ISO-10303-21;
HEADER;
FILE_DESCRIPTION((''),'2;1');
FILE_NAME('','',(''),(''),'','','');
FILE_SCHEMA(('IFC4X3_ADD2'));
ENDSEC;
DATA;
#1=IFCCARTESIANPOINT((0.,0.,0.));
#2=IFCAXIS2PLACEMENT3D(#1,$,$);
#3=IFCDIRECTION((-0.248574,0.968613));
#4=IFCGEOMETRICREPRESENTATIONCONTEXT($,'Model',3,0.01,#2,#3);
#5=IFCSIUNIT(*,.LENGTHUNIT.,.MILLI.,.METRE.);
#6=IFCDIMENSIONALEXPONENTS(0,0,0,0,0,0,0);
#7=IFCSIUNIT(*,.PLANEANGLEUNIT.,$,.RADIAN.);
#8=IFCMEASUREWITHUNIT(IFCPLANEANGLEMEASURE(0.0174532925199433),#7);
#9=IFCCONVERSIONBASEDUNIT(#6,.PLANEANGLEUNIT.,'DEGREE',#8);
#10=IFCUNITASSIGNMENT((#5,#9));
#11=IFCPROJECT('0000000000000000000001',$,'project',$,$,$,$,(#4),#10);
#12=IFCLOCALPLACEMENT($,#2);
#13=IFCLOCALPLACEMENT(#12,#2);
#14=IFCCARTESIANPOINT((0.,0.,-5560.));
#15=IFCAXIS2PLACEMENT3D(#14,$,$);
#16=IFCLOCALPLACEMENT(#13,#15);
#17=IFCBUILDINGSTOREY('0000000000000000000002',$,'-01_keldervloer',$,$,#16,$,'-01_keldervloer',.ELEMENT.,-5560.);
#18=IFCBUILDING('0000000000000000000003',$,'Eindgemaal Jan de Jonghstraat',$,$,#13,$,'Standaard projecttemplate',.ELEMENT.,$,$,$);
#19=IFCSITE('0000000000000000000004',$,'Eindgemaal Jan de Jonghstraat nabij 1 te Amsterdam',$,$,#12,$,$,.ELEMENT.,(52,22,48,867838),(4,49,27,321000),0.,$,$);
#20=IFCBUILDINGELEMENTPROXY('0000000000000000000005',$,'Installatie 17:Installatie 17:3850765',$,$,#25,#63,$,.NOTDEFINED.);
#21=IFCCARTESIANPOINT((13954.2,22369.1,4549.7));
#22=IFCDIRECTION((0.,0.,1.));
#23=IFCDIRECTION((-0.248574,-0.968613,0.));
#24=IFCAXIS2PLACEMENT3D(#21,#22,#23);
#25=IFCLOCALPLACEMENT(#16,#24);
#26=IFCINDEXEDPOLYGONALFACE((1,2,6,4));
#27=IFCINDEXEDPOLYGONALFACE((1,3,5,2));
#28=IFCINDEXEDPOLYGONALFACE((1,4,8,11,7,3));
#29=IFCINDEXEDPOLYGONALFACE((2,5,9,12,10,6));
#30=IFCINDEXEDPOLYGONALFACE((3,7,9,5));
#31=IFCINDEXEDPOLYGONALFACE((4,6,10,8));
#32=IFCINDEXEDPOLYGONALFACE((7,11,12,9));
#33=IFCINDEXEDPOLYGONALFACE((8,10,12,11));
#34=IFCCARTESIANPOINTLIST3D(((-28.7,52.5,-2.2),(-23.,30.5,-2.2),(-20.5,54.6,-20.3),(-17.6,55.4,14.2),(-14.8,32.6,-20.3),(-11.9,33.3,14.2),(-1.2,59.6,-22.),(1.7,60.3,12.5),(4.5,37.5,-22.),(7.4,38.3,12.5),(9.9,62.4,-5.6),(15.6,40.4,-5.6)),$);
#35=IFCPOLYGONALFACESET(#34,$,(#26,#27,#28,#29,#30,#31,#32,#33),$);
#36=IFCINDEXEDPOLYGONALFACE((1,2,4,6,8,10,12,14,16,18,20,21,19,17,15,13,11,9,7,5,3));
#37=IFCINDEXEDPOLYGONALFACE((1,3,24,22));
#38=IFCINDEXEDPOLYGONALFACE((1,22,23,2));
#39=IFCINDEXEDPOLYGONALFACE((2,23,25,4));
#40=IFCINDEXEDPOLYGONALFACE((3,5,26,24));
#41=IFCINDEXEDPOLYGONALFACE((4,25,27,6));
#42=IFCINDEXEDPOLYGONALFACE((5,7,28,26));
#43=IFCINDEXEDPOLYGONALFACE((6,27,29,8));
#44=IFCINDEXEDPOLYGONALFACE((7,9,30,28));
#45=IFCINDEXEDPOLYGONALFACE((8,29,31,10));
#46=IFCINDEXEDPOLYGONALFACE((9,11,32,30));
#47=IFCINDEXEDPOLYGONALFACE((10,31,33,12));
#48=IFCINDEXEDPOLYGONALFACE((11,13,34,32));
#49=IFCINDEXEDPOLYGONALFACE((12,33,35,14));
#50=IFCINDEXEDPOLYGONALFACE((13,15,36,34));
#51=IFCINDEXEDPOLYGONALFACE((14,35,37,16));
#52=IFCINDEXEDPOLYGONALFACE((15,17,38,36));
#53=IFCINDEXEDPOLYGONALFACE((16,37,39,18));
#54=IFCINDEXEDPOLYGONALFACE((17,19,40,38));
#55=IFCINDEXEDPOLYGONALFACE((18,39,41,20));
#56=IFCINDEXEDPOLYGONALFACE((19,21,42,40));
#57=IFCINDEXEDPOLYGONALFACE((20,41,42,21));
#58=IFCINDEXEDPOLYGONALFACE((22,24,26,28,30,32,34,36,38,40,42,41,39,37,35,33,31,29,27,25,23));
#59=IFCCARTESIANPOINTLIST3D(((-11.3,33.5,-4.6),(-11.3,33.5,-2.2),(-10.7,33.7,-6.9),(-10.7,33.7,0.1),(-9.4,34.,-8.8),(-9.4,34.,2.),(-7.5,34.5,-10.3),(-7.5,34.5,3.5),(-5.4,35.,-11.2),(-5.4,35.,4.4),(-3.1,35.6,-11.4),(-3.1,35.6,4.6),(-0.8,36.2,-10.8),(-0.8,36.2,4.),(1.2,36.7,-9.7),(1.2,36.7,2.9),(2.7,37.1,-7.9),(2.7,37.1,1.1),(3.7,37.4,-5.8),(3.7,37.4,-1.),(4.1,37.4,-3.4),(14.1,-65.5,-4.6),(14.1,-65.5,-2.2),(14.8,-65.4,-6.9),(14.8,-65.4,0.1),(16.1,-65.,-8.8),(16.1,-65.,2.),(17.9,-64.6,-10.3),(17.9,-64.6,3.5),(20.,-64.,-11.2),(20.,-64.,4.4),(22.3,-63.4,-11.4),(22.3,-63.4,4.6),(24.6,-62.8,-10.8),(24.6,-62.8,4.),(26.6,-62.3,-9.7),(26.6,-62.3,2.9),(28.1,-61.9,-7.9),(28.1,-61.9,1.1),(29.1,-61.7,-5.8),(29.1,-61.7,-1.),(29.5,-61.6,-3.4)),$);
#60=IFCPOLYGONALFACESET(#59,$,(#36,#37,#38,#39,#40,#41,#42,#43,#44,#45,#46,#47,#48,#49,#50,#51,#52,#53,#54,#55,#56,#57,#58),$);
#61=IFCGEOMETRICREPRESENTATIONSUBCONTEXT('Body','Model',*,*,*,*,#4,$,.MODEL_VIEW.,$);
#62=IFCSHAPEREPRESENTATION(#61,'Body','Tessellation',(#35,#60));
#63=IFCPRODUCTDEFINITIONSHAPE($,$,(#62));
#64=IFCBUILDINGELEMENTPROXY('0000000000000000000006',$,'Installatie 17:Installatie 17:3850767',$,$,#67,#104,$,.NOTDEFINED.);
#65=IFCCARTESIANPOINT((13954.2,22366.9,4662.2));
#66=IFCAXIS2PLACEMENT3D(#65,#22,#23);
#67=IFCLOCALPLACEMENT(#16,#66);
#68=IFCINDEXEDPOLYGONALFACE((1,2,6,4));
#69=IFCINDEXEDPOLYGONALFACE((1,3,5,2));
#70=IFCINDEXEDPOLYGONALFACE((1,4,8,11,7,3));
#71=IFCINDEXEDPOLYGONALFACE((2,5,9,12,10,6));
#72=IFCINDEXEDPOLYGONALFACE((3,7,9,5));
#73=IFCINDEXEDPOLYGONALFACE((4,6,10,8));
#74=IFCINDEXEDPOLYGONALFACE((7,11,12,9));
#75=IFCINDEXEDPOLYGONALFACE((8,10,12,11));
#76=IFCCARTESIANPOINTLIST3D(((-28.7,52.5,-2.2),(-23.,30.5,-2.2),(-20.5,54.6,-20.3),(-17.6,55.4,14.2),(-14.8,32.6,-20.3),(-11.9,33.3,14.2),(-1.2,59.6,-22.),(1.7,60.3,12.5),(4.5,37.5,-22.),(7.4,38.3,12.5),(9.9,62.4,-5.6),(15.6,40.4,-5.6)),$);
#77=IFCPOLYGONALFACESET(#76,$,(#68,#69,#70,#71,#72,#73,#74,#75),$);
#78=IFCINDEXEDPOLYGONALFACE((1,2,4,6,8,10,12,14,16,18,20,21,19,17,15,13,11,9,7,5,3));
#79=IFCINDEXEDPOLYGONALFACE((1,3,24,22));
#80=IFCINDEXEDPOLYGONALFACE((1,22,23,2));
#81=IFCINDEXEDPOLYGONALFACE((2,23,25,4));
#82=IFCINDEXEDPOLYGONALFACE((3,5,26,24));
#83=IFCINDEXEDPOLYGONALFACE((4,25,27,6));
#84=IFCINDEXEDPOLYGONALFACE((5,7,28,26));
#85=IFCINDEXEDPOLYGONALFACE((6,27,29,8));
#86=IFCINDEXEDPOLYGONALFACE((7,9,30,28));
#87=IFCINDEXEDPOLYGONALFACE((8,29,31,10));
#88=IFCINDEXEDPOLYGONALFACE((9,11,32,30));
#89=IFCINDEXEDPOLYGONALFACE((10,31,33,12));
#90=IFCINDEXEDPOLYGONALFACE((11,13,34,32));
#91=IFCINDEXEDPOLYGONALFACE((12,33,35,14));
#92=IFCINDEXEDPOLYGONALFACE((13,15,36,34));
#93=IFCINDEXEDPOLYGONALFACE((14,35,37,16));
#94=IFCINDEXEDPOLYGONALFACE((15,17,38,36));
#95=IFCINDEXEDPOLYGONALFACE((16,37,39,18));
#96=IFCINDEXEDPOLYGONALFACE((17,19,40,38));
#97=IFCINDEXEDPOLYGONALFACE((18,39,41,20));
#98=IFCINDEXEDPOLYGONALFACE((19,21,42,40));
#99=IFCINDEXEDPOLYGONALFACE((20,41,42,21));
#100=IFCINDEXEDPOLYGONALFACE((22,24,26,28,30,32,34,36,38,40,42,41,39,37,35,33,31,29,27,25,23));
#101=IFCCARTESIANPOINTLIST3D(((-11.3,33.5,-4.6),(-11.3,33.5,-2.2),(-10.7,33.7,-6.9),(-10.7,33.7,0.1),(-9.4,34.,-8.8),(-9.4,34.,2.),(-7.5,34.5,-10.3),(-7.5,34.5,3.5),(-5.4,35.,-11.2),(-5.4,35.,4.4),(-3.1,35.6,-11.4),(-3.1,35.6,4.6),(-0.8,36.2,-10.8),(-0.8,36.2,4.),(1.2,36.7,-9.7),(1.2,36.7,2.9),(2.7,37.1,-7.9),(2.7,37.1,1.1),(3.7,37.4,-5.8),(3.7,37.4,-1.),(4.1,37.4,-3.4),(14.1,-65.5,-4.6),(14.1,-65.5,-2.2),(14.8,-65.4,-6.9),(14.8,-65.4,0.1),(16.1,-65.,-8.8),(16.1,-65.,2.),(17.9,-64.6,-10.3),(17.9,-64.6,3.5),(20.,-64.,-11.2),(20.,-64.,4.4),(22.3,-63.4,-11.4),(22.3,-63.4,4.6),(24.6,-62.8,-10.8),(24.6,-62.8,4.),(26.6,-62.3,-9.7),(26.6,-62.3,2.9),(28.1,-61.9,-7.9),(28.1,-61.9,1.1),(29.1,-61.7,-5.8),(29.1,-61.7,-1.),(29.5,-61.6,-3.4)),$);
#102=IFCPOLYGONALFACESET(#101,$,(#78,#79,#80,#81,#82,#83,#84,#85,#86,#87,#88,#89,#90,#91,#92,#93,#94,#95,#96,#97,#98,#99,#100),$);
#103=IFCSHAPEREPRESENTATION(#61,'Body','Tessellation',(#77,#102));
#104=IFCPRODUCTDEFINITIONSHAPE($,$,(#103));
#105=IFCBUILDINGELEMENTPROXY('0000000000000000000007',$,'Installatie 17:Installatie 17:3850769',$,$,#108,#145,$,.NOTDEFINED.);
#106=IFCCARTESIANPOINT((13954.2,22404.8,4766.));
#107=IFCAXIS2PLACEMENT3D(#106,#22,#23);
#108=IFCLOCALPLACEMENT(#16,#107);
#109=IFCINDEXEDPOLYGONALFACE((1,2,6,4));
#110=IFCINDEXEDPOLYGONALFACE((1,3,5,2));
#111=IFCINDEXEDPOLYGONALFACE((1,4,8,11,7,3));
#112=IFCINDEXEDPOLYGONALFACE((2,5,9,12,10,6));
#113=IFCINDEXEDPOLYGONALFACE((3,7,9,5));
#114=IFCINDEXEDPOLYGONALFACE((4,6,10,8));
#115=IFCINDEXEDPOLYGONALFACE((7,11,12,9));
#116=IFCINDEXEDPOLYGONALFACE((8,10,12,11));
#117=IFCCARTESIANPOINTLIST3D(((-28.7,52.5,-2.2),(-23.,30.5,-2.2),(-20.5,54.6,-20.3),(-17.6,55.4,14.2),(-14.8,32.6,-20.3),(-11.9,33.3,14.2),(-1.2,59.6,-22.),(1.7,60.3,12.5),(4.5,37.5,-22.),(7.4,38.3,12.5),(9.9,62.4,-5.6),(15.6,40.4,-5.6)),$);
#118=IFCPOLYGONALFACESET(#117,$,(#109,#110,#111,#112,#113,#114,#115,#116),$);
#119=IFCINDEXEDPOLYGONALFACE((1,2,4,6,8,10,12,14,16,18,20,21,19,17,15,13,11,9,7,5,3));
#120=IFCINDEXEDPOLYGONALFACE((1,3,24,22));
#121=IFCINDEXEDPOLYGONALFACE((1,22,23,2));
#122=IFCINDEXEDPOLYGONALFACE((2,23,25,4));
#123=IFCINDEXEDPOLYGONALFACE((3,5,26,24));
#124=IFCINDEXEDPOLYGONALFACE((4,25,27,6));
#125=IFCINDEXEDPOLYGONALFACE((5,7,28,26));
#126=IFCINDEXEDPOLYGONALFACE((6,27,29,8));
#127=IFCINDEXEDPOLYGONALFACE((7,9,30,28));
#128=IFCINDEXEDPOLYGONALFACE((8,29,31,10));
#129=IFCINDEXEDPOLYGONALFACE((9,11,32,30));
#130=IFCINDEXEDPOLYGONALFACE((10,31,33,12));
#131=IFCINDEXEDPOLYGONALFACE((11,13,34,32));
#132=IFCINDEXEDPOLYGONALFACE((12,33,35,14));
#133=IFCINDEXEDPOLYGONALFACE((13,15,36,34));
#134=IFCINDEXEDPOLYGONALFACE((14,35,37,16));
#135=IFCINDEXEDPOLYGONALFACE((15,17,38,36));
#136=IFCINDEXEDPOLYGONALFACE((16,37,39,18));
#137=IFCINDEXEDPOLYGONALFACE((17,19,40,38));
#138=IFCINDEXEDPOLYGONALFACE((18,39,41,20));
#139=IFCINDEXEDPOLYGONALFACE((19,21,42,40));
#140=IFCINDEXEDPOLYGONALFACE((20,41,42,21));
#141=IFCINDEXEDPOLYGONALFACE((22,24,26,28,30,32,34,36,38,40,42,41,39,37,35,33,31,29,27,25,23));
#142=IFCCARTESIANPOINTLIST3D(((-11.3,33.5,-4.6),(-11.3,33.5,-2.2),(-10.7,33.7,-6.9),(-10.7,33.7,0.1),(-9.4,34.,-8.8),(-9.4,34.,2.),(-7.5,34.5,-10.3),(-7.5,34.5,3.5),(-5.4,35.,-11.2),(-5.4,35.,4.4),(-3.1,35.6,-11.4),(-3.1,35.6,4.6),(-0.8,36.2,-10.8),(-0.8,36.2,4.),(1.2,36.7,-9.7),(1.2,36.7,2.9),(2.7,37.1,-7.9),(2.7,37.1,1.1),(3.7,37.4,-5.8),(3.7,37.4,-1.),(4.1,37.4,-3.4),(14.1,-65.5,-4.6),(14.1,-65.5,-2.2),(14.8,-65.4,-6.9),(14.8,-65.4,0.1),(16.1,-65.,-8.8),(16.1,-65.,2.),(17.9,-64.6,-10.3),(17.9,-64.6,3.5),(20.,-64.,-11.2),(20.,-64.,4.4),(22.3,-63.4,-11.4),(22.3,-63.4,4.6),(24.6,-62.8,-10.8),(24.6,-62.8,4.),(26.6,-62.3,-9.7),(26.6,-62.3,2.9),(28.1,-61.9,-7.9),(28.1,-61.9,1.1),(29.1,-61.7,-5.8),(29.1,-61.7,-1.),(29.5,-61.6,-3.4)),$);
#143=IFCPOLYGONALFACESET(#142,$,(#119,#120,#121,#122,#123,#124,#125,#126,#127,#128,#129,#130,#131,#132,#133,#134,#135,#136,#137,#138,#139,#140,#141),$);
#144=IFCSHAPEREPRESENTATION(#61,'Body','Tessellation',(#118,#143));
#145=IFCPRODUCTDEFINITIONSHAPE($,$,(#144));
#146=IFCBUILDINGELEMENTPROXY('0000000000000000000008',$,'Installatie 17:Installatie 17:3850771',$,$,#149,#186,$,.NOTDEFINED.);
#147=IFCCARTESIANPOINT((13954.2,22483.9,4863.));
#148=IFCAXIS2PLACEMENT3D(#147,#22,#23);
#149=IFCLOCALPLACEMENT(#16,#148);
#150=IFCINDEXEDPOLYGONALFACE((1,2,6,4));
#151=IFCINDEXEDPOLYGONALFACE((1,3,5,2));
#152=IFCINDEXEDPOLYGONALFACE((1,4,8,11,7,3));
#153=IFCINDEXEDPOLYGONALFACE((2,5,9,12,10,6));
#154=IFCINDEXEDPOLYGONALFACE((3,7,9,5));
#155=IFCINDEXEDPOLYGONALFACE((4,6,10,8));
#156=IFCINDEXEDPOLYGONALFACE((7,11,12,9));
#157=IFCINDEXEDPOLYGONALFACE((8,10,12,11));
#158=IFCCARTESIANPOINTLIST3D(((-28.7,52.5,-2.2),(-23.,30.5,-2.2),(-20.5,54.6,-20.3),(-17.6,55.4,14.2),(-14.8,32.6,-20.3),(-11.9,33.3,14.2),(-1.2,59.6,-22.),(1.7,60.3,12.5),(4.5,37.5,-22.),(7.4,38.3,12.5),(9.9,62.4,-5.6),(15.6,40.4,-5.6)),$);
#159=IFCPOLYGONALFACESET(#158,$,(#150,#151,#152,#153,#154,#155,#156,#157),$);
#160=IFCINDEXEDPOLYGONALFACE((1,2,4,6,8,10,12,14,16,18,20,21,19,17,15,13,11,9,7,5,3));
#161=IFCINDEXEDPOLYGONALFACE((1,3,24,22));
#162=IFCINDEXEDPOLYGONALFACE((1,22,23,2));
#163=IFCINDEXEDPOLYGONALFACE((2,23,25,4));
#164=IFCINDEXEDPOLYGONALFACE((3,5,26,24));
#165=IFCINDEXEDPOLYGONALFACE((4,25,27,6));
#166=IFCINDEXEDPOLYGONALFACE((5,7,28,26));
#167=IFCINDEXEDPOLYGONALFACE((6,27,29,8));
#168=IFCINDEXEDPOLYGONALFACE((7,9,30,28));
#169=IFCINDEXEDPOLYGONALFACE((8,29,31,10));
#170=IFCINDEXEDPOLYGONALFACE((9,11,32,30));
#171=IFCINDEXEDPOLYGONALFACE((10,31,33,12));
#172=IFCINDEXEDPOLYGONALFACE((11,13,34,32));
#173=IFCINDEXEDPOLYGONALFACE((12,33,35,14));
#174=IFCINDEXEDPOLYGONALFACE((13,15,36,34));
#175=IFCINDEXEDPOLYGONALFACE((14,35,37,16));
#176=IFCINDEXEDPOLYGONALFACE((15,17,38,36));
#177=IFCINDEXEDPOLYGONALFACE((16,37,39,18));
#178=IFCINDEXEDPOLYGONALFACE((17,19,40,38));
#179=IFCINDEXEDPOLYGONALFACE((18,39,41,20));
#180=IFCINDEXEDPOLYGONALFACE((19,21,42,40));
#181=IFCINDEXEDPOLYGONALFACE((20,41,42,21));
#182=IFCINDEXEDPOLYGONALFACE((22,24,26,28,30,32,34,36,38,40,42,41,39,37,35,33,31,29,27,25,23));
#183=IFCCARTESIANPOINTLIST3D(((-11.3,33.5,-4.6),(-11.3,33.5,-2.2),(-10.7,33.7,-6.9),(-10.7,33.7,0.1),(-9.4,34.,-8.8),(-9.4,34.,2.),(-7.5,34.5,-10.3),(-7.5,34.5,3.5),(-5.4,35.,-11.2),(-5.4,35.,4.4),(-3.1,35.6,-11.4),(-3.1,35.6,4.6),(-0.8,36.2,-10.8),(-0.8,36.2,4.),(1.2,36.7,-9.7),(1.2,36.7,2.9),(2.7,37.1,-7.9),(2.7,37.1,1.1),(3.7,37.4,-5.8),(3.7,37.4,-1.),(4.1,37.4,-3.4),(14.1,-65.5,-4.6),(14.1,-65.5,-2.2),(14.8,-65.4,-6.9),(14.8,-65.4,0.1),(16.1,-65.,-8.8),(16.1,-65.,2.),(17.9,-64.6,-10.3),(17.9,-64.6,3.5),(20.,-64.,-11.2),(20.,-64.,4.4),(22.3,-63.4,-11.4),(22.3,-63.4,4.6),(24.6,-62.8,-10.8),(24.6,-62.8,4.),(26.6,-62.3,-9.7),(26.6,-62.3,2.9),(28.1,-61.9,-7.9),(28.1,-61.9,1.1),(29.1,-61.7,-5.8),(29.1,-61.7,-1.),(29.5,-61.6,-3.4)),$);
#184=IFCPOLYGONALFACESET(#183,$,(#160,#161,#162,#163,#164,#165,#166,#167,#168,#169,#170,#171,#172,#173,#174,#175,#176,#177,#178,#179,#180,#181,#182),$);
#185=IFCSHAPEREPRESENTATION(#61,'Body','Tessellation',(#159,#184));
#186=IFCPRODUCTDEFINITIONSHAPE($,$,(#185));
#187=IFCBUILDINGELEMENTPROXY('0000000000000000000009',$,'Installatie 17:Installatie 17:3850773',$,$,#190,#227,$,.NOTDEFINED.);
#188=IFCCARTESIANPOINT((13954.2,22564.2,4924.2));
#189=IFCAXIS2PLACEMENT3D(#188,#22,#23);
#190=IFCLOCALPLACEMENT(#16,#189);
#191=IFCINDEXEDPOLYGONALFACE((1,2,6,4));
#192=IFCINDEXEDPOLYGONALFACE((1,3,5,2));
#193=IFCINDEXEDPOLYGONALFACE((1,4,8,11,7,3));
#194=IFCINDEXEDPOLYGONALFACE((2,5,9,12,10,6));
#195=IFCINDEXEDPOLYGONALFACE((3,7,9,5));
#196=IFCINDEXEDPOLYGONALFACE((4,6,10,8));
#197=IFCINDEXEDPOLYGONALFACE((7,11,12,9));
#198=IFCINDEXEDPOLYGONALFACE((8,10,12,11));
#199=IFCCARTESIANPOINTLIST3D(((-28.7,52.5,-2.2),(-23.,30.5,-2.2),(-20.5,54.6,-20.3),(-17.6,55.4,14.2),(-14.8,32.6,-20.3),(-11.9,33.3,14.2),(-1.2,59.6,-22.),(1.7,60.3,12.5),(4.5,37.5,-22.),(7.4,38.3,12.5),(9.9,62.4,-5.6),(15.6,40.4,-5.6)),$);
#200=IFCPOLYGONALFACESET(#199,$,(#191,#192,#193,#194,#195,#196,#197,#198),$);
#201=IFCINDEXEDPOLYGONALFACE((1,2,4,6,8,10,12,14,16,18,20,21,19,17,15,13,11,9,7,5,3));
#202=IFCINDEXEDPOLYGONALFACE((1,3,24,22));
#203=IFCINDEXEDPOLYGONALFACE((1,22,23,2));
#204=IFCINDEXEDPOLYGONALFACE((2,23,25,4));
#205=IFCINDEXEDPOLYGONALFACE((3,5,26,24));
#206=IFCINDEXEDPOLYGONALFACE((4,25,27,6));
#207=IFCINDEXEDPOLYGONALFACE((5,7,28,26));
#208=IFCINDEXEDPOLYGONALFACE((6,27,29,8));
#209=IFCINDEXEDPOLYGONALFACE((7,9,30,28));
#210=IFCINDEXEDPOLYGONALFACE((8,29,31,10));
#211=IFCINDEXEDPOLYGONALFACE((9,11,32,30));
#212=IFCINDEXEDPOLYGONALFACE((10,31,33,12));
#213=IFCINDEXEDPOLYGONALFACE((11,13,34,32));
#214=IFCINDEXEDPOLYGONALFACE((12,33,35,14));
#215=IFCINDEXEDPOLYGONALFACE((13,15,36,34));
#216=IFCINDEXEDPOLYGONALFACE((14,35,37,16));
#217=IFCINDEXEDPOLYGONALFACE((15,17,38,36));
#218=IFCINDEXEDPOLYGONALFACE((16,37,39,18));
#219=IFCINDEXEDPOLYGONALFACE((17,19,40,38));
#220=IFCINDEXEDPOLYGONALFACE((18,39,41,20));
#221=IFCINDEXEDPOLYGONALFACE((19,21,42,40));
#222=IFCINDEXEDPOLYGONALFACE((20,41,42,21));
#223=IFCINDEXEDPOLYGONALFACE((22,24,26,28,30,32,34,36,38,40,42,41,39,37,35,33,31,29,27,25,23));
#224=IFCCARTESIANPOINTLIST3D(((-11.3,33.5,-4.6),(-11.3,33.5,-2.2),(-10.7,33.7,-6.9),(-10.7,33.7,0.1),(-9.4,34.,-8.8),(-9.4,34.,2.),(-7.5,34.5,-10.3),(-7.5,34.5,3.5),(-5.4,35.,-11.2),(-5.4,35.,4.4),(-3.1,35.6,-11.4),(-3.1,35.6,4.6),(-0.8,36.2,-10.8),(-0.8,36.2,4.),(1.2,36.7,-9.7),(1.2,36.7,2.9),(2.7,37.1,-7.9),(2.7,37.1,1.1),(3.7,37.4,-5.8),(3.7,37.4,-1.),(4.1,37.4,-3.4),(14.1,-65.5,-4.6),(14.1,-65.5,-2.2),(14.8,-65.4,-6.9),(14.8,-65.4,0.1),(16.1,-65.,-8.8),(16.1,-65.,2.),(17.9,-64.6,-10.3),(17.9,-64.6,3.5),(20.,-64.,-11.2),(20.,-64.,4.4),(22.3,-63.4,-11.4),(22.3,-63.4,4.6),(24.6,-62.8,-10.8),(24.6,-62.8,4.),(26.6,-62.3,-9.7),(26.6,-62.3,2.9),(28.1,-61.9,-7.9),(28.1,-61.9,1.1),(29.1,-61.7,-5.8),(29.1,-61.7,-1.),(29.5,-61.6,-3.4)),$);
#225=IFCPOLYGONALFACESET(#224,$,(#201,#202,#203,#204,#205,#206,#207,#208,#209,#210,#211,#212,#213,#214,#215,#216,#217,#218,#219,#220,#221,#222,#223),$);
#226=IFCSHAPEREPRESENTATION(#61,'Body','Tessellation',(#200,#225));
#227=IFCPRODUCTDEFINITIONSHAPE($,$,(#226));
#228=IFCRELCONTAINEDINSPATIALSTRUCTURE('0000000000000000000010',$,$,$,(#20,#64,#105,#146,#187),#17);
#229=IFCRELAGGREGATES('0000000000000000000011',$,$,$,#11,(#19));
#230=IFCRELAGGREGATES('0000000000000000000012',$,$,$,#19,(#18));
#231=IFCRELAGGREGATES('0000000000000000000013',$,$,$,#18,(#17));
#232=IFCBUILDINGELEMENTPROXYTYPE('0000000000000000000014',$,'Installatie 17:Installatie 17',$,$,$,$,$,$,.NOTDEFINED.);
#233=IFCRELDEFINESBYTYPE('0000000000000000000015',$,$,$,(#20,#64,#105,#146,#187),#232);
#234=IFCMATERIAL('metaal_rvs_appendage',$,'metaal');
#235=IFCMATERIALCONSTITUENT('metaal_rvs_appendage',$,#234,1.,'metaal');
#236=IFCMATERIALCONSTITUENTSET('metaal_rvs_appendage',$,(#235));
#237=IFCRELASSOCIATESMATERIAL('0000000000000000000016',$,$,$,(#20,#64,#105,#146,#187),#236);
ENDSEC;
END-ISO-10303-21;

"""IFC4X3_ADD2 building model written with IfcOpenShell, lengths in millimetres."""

from ifc_helpers import new_model, entity, si_unit, converted_unit, direction, frame, frame_2d, origin, place, context, subcontext, project, spatial, polyline, circle, outline, extrude, source, transform, mapped, material, constituent, constituent_set, type_object, type_shapes, element, save


model = new_model("IFC4X3_ADD2")

# Units and contexts
model_context = context("Model", 3, precision=0.01, world=origin(), true_north=direction((-0.248574, 0.968613)))
body_context = subcontext(model_context, "Body", "Model", "MODEL_VIEW")
ifc_project = project(units=[si_unit("LENGTHUNIT", "METRE", prefix="MILLI"), converted_unit("PLANEANGLEUNIT", "DEGREE", entity("IfcPlaneAngleMeasure", 0.0174532925199433), si_unit("PLANEANGLEUNIT", "RADIAN"), dimensions=[0, 0, 0, 0, 0, 0, 0])], contexts=[model_context])

# Site, building, storey
site_placement = place(None, origin())
site = spatial("IfcSite", under=ifc_project, at=site_placement, Name="Eindgemaal Jan de Jonghstraat nabij 1 te Amsterdam", CompositionType="ELEMENT", RefLatitude=(52, 22, 48, 867838), RefLongitude=(4, 49, 27, 321000), RefElevation=0.0)
building_placement = place(site_placement, origin())
building = spatial("IfcBuilding", under=site, at=building_placement, Name="Eindgemaal Jan de Jonghstraat", LongName="Standaard projecttemplate", CompositionType="ELEMENT")
storey_placement = place(building_placement, frame((0.0, 0.0, -5560.0)))
storey = spatial("IfcBuildingStorey", under=building, at=storey_placement, Name="-01_keldervloer", LongName="-01_keldervloer", CompositionType="ELEMENT", Elevation=-5560.0)

# Building element proxies
ifc_material_1 = material(Name="metaal_rvs_appendage", Category="metaal")
ifc_constituent_1 = constituent(ifc_material_1, Name="metaal_rvs_appendage", Category="metaal", fraction=1.0)
ifc_constituent_set_1 = constituent_set(constituents=[ifc_constituent_1], Name="metaal_rvs_appendage")
building_element_proxy_type_1 = type_object("IfcBuildingElementProxyType", Name="Installatie 17:Installatie 17", PredefinedType="NOTDEFINED")
shared_shape_1 = source(origin(), body_context, "Body", "SweptSolid", [
    extrude(outline(polyline([(-10.0, -17.3), (10.0, -17.3), (20.0, 0.0), (10.0, 17.3), (-10.0, 17.3), (-20.0, 0.0), (-10.0, -17.3)])), frame((-3.7, 35.4, -3.9), z_axis=(-0.248574, 0.968613, 0.0), x_axis=(-0.555573, -0.142576, -0.819152)), (0.0, 0.0, 1.0), 22.8),
    extrude(circle(Radius=8.0, at=frame_2d((0.0, 0.0), x_axis=(1.0, 0.0))), frame((21.7, -63.6, -3.4), z_axis=(-0.248574, 0.968613, 0.0), x_axis=(0.968613, 0.248574, 0.0)), (0.0, 0.0, 1.0), 102.2),
])
type_shapes(building_element_proxy_type_1, [shared_shape_1])
for number, where, z_axis, x_axis, name in (
    (1, (13954.2, 22369.1, 4549.7), (0.0, 0.0, 1.0), (-0.248574, -0.968613, 0.0), "Installatie 17:Installatie 17:3850765"),
    (2, (13954.2, 22366.9, 4662.2), (0.0, 0.0, 1.0), (-0.248574, -0.968613, 0.0), "Installatie 17:Installatie 17:3850767"),
    (3, (13954.2, 22404.8, 4766.0), (0.0, 0.0, 1.0), (-0.248574, -0.968613, 0.0), "Installatie 17:Installatie 17:3850769"),
    (4, (13954.2, 22483.9, 4863.0), (0.0, 0.0, 1.0), (-0.248574, -0.968613, 0.0), "Installatie 17:Installatie 17:3850771"),
    (5, (13954.2, 22564.2, 4924.2), (0.0, 0.0, 1.0), (-0.248574, -0.968613, 0.0), "Installatie 17:Installatie 17:3850773"),
):
    element("IfcBuildingElementProxy", number, at=place(storey_placement, frame(where, z_axis=z_axis, x_axis=x_axis)), inside=storey, type_object=building_element_proxy_type_1, material=ifc_constituent_set_1, Name=name, PredefinedType="NOTDEFINED", context=body_context, shape_type="MappedRepresentation", body=[
        mapped(shared_shape_1, transform((0.0, 0.0, 0.0), scale=1.0)),
    ])

save(model, "model.ifc")
